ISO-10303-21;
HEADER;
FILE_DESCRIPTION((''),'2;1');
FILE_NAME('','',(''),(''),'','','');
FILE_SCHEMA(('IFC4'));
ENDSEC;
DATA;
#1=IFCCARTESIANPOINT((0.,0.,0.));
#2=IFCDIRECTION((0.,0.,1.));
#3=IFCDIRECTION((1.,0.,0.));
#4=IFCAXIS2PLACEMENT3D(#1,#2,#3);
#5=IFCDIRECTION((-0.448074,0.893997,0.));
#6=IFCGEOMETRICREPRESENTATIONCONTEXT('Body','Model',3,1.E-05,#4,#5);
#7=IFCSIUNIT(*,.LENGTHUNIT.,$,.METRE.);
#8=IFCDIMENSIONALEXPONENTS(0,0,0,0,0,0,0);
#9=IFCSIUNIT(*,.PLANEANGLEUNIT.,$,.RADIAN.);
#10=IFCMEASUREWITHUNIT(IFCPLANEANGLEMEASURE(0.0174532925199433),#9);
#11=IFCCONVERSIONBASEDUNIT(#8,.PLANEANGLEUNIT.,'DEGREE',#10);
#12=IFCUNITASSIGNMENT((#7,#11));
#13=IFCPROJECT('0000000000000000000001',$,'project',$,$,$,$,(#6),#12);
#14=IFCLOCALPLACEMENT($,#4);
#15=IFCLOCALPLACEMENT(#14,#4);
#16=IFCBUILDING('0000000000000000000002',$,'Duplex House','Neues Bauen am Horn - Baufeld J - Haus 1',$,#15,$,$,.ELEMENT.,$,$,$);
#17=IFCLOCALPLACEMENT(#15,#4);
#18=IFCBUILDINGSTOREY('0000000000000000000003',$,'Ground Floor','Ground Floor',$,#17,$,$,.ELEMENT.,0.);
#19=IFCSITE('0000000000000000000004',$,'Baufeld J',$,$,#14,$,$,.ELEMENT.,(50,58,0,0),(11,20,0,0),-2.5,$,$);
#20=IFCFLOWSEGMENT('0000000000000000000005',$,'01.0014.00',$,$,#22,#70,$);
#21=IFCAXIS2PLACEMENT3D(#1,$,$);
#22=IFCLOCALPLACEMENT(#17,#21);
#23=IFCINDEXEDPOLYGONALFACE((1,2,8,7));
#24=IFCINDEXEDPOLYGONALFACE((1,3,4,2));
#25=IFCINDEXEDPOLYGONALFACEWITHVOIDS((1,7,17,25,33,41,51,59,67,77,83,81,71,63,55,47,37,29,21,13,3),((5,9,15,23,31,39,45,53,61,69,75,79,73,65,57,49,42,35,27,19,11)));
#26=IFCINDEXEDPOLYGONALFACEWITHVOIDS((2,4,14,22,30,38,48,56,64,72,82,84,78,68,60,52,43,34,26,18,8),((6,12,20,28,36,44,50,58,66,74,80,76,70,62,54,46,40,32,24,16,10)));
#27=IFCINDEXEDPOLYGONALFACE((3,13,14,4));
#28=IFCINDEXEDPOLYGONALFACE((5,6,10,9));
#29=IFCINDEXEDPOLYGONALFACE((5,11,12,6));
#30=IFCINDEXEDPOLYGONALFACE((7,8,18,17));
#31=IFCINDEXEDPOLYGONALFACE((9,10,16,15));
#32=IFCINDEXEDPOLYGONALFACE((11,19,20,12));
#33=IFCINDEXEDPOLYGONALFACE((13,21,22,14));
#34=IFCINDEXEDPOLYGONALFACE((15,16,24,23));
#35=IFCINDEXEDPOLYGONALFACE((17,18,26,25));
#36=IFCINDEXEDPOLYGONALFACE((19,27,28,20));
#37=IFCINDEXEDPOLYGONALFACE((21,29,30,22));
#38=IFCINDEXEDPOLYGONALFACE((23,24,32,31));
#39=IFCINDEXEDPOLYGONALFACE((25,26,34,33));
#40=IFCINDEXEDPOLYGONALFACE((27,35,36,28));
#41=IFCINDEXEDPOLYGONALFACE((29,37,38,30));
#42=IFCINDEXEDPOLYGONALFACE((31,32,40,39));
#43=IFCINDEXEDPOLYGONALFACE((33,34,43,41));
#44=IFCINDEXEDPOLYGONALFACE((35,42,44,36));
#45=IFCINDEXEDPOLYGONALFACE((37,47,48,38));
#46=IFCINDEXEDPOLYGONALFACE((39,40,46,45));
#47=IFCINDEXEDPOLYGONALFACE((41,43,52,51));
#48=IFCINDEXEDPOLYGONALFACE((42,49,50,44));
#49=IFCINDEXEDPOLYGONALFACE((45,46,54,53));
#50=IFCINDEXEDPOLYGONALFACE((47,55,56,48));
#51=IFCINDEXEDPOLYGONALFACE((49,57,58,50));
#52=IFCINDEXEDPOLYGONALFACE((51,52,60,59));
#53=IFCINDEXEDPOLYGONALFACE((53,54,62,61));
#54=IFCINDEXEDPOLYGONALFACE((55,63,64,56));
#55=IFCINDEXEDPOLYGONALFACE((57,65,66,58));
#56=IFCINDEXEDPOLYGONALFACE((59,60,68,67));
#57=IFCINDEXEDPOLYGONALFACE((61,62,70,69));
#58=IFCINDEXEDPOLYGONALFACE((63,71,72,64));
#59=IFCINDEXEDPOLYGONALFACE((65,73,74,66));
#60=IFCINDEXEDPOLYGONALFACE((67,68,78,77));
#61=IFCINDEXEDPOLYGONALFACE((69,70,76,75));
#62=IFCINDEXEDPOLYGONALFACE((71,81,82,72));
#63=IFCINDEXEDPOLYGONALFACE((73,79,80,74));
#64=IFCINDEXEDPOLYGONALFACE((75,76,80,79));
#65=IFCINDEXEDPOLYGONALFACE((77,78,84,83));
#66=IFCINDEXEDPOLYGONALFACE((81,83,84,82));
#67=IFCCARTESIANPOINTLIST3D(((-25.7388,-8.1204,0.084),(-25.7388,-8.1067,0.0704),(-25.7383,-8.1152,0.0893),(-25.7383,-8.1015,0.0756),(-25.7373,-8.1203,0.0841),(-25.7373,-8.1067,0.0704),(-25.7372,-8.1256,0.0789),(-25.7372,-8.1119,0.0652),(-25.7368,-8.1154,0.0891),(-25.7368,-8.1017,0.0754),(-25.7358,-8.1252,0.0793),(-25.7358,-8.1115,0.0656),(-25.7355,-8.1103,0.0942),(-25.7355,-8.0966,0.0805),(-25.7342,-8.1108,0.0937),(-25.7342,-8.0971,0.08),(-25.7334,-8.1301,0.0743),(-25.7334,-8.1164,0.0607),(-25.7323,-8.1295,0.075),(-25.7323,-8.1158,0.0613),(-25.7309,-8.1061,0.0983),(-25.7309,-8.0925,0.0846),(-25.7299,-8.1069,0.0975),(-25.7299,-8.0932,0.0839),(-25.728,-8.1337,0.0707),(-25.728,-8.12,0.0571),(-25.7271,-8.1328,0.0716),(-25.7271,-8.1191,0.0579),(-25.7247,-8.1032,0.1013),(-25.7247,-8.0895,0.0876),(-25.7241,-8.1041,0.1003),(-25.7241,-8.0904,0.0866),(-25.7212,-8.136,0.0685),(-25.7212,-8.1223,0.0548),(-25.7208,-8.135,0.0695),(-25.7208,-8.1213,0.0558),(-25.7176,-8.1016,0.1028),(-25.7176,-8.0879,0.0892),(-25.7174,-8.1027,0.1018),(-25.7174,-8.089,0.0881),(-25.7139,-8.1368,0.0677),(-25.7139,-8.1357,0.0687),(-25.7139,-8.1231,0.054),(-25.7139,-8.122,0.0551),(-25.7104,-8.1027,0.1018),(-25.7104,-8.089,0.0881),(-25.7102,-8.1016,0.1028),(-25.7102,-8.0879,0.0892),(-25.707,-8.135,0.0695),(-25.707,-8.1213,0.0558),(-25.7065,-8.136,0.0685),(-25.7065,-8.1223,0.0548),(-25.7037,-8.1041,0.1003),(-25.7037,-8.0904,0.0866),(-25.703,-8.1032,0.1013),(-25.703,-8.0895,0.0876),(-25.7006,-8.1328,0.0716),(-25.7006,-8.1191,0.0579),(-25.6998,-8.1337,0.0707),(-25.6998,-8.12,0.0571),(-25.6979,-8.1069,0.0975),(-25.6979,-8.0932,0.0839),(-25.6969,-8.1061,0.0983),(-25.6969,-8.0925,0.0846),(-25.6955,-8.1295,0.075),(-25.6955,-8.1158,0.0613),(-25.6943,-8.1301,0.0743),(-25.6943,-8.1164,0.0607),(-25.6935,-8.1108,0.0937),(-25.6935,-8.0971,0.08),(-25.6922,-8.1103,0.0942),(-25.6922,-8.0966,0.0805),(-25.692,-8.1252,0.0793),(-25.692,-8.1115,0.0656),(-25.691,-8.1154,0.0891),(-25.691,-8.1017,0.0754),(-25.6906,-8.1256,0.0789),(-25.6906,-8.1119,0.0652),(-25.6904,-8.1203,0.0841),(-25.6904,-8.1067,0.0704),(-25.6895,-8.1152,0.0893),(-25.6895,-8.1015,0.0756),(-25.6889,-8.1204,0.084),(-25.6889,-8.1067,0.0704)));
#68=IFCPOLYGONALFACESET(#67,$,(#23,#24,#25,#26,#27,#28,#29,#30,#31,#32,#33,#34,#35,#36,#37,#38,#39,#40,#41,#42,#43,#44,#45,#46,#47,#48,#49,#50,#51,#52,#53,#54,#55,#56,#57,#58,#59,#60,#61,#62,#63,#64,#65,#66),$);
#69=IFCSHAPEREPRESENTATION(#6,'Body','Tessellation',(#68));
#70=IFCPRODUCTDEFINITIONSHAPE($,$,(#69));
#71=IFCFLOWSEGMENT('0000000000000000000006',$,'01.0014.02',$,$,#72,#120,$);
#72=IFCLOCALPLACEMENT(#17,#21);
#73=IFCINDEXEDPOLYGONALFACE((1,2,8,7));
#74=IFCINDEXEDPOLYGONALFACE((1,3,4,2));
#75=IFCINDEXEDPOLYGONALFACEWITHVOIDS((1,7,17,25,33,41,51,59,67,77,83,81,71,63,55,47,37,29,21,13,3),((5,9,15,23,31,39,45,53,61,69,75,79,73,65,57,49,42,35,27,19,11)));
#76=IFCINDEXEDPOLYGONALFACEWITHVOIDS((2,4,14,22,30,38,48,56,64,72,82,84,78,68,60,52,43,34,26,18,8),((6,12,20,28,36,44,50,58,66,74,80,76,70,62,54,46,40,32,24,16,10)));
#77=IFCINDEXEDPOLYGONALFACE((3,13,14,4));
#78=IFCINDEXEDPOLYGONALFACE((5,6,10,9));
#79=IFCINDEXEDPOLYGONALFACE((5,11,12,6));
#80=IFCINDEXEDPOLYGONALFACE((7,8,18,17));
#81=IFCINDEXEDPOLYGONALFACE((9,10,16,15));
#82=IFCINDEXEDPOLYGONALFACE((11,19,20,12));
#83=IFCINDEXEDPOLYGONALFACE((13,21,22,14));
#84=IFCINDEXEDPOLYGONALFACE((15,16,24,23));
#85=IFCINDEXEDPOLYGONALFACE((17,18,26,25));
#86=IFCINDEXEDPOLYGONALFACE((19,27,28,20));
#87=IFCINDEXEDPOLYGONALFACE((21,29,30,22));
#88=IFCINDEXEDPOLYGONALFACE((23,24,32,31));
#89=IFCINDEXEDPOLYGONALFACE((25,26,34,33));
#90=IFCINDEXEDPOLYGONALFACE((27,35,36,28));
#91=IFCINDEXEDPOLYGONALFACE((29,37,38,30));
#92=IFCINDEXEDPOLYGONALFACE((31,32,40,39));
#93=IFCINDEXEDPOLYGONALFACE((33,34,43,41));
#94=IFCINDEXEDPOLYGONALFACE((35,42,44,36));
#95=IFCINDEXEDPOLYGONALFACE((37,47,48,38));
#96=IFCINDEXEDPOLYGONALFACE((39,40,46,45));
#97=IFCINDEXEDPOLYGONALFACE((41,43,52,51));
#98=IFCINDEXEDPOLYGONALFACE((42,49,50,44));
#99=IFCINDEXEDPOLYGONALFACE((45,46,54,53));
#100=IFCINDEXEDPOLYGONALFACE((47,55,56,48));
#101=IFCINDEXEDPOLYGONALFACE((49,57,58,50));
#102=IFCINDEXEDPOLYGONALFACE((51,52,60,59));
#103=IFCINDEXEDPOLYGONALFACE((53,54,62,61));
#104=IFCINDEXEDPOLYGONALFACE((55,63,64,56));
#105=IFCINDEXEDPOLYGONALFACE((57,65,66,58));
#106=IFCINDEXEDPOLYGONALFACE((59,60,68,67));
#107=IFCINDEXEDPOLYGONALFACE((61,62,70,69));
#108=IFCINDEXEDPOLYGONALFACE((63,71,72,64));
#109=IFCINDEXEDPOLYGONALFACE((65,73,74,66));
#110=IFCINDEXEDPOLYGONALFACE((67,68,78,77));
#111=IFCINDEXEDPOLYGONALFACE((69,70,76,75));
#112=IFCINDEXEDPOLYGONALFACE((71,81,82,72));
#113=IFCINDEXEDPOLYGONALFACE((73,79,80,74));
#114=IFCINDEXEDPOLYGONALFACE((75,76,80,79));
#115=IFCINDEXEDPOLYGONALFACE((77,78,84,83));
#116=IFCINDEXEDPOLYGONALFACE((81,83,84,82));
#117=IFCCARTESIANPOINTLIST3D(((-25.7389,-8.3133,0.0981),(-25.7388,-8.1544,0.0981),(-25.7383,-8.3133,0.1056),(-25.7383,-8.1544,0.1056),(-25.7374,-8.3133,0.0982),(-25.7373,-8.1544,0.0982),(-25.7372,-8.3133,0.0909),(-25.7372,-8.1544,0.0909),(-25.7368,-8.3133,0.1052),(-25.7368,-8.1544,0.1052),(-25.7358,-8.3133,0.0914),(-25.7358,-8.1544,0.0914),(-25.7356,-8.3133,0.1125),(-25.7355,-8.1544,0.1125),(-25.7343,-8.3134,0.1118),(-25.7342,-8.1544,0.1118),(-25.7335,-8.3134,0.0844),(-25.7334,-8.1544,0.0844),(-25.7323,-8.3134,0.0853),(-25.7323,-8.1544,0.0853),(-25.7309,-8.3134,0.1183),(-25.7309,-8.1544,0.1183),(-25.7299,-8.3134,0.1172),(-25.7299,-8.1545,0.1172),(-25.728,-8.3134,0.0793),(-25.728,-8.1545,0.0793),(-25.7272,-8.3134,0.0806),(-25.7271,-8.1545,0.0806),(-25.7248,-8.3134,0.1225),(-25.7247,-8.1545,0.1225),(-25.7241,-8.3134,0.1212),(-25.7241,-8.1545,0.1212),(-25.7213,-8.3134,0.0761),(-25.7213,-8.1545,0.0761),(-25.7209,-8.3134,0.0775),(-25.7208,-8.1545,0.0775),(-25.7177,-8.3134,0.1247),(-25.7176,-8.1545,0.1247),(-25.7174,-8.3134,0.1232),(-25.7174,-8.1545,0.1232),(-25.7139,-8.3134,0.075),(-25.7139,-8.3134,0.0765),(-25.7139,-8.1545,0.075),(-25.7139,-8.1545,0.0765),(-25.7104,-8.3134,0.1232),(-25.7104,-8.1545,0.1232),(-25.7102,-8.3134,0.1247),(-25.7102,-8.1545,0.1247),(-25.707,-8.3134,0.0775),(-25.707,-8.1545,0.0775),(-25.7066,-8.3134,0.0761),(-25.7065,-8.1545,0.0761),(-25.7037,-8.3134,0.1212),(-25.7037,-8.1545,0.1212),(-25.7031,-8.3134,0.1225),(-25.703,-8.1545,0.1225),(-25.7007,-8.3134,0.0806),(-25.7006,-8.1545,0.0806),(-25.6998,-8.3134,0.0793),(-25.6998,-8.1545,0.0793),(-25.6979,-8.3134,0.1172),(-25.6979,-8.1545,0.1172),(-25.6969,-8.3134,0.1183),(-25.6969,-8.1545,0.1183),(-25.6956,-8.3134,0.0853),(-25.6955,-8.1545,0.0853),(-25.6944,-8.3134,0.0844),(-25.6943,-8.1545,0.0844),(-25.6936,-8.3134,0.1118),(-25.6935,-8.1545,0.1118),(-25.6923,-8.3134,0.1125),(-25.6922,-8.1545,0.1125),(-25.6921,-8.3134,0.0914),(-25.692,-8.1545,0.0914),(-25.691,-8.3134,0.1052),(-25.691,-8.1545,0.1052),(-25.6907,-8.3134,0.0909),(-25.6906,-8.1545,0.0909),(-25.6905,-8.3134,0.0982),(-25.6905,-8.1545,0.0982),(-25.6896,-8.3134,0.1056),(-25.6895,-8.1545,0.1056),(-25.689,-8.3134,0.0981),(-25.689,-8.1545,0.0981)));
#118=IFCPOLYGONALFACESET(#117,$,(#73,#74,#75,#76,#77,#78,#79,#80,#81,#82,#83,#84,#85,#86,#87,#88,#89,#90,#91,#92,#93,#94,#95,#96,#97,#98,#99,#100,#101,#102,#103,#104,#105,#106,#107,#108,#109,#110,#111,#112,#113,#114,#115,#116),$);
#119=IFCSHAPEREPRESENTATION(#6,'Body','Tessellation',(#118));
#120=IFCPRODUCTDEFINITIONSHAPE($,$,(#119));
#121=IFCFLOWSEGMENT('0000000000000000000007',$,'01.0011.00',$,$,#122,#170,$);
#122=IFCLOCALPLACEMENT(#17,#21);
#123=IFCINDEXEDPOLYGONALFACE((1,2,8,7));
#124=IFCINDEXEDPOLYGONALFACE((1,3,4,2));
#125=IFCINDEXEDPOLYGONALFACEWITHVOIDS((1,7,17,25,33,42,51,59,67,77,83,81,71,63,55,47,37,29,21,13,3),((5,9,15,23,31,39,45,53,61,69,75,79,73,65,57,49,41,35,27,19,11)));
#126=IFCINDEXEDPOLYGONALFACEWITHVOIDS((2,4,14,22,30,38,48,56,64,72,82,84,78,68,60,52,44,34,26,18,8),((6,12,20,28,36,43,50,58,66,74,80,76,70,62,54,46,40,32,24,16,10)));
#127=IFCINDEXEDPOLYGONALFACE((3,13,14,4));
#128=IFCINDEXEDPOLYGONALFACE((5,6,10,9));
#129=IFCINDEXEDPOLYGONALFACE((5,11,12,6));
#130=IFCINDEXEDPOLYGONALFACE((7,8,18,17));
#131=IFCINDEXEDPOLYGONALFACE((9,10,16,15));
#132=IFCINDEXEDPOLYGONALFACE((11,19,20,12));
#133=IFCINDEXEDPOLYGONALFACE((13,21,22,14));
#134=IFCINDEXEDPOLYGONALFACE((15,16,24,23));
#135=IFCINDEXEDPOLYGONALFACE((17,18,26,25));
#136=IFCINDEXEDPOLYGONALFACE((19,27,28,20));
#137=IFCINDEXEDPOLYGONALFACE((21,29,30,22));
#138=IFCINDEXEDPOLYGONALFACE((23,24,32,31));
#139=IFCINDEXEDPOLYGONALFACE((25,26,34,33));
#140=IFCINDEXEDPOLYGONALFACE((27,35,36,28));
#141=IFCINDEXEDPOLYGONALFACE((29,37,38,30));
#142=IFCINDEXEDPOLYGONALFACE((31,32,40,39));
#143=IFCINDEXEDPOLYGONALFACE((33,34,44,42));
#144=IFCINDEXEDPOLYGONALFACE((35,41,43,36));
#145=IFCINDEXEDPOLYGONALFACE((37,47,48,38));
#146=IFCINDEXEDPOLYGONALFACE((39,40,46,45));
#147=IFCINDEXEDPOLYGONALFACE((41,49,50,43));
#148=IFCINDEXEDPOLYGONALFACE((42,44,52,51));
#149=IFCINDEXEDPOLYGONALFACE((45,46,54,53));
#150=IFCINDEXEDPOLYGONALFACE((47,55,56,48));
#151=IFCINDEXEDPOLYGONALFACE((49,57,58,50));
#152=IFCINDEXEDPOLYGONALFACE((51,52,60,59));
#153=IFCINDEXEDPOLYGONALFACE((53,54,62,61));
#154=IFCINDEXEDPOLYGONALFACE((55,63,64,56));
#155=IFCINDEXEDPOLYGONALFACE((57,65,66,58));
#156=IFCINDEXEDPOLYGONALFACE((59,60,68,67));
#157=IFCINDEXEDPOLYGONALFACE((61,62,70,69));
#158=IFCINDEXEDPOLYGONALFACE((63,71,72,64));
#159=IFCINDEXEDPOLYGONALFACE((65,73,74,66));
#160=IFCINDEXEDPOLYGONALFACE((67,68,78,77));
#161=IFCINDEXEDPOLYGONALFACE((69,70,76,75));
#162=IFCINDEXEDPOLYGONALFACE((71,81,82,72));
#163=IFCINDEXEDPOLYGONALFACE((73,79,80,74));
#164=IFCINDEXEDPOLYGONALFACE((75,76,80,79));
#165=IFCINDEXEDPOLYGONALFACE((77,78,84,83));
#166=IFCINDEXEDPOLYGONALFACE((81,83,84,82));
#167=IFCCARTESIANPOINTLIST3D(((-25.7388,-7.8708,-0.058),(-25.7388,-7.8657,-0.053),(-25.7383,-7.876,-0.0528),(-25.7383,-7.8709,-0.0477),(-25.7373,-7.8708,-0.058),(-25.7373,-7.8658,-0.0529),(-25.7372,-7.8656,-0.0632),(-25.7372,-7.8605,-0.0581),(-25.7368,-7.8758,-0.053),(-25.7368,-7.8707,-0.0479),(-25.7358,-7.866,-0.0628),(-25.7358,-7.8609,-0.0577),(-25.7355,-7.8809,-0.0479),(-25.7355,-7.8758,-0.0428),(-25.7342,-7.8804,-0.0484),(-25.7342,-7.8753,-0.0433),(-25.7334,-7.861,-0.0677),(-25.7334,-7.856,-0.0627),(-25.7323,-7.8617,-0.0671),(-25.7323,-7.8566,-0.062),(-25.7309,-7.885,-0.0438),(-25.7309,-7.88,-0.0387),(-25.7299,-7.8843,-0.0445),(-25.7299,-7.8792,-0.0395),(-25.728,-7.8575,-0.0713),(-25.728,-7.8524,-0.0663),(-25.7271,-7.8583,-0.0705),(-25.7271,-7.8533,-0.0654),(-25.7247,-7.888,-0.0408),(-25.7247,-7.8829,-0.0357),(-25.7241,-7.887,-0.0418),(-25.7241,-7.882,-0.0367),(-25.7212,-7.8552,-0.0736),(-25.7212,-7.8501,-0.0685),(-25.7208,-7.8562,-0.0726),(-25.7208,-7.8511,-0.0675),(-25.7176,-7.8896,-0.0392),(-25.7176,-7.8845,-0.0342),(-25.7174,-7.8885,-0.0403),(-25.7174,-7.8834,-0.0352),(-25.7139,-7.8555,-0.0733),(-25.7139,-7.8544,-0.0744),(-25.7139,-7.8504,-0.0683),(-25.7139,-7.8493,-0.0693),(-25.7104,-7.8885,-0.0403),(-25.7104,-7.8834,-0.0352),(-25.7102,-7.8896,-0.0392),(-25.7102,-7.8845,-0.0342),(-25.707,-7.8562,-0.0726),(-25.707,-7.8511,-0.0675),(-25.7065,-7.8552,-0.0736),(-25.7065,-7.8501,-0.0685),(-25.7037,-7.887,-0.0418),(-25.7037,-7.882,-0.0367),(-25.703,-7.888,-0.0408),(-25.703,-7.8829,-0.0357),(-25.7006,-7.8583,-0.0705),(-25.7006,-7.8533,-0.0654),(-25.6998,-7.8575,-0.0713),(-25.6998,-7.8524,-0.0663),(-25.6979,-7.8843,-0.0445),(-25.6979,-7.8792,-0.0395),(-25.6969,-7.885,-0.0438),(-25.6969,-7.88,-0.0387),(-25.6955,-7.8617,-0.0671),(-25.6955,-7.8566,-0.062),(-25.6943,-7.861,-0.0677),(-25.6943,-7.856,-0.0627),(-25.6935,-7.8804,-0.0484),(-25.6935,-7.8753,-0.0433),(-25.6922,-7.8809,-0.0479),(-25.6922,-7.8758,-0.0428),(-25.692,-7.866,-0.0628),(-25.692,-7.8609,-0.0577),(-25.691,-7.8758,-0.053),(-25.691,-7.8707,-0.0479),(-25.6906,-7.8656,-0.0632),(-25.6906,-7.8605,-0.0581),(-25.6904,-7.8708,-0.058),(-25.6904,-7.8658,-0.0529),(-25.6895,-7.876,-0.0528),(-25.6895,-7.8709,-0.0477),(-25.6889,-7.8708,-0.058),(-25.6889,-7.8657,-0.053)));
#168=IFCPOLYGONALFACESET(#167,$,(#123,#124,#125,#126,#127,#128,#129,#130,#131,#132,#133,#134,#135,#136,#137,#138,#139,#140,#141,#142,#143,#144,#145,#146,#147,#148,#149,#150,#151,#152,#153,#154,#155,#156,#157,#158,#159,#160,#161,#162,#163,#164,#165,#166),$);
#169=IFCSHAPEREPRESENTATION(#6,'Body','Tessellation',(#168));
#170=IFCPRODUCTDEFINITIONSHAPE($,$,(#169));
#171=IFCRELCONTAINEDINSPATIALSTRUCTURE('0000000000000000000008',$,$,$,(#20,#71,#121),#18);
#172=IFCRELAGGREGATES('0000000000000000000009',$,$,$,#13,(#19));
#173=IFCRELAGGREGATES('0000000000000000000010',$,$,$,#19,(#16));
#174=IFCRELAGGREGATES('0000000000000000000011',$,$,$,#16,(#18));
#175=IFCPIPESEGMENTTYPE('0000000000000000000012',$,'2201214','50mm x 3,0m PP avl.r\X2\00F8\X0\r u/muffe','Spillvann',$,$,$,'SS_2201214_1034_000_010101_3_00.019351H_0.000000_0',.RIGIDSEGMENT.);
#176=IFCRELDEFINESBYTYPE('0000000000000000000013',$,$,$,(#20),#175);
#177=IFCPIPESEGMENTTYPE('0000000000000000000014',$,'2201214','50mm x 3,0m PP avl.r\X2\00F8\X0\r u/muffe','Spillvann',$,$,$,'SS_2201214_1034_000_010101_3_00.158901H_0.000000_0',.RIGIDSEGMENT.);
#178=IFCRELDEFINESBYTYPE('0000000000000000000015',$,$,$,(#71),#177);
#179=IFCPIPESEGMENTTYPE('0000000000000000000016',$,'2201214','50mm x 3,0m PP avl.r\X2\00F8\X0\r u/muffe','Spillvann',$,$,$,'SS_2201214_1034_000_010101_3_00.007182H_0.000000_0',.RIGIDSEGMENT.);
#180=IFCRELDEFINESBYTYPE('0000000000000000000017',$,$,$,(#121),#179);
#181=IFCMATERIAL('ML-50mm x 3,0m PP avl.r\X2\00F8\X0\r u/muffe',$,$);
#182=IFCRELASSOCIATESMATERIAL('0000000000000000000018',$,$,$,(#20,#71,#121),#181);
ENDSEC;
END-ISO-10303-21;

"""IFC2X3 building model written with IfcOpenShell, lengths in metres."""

from ifc_helpers import new_model, entity, si_unit, converted_unit, direction, frame, origin_with_axes, origin_2d_with_axis, place, context, project, spatial, hollow_circle, extrude, material, type_object, element, save


model = new_model("IFC2X3")

# Units and contexts
model_context = context("Model", 3, precision=1e-05, world=origin_with_axes(), true_north=direction((-0.448074, 0.893997, 0.0)), identifier="Body")
ifc_project = project(units=[si_unit("LENGTHUNIT", "METRE"), converted_unit("PLANEANGLEUNIT", "DEGREE", entity("IfcPlaneAngleMeasure", 0.0174532925199433), si_unit("PLANEANGLEUNIT", "RADIAN"), dimensions=[0, 0, 0, 0, 0, 0, 0])], contexts=[model_context])

# Site, building, storey
site_placement = place(None, origin_with_axes())
site = spatial("IfcSite", under=ifc_project, at=site_placement, Name="Baufeld J", CompositionType="ELEMENT", RefLatitude=(50, 58, 0, 0), RefLongitude=(11, 20, 0, 0), RefElevation=-2.5)
building_placement = place(site_placement, origin_with_axes())
building = spatial("IfcBuilding", under=site, at=building_placement, Name="Duplex House", Description="Neues Bauen am Horn - Baufeld J - Haus 1", CompositionType="ELEMENT")
storey_placement = place(building_placement, origin_with_axes())
storey = spatial("IfcBuildingStorey", under=building, at=storey_placement, Name="Ground Floor", Description="Ground Floor", CompositionType="ELEMENT", Elevation=0.0)

# Flow segments
ifc_material_1 = material(Name="ML-50mm x 3,0m PP avl.rør u/muffe")
pipe_segment_type_1 = type_object("IfcPipeSegmentType", Name="2201214", Description="50mm x 3,0m PP avl.rør u/muffe", ApplicableOccurrence="Spillvann", ElementType="SS_2201214_1034_000_010101_3_00.019351H_0.000000_0", PredefinedType="RIGIDSEGMENT")
flow_segment_1_placement = place(storey_placement, frame((-25.7139, -8.1054, 0.0717), z_axis=(0.0, 0.707107, 0.707107), x_axis=(0.0, -0.707107, 0.707107)))
element("IfcFlowSegment", 1, at=flow_segment_1_placement, inside=storey, type_object=pipe_segment_type_1, material=ifc_material_1, Name="01.0014.00", context=model_context, shape_type="SweptSolid", body=[
    extrude(hollow_circle(Radius=0.025, WallThickness=0.0015, at=origin_2d_with_axis()), frame((0.0, 0.0, 0.0), z_axis=(1.0, 0.0, 0.0), x_axis=(0.0, 0.0, -1.0)), (0.0, 0.0, 1.0), 0.0194),
])
pipe_segment_type_2 = type_object("IfcPipeSegmentType", Name="2201214", Description="50mm x 3,0m PP avl.rør u/muffe", ApplicableOccurrence="Spillvann", ElementType="SS_2201214_1034_000_010101_3_00.158901H_0.000000_0", PredefinedType="RIGIDSEGMENT")
flow_segment_2_placement = place(storey_placement, frame((-25.7139, -8.1545, 0.1), z_axis=(0.0, 0.0, 1.0), x_axis=(-0.000303, -1.0, 0.0)))
element("IfcFlowSegment", 2, at=flow_segment_2_placement, inside=storey, type_object=pipe_segment_type_2, material=ifc_material_1, Name="01.0014.02", context=model_context, shape_type="SweptSolid", body=[
    extrude(hollow_circle(Radius=0.025, WallThickness=0.0015, at=origin_2d_with_axis()), frame((0.0, 0.0, 0.0), z_axis=(1.0, 0.0, 0.0), x_axis=(0.0, 0.0, -1.0)), (0.0, 0.0, 1.0), 0.1589),
])
pipe_segment_type_3 = type_object("IfcPipeSegmentType", Name="2201214", Description="50mm x 3,0m PP avl.rør u/muffe", ApplicableOccurrence="Spillvann", ElementType="SS_2201214_1034_000_010101_3_00.007182H_0.000000_0", PredefinedType="RIGIDSEGMENT")
flow_segment_3_placement = place(storey_placement, frame((-25.7139, -7.8721, -0.0567), z_axis=(0.0, -0.707107, 0.707107), x_axis=(0.0, 0.707107, 0.707107)))
element("IfcFlowSegment", 3, at=flow_segment_3_placement, inside=storey, type_object=pipe_segment_type_3, material=ifc_material_1, Name="01.0011.00", context=model_context, shape_type="SweptSolid", body=[
    extrude(hollow_circle(Radius=0.025, WallThickness=0.0015, at=origin_2d_with_axis()), frame((0.0, 0.0, 0.0), z_axis=(1.0, 0.0, 0.0), x_axis=(0.0, 0.0, -1.0)), (0.0, 0.0, 1.0), 0.0072),
])

save(model, "model.ifc")
